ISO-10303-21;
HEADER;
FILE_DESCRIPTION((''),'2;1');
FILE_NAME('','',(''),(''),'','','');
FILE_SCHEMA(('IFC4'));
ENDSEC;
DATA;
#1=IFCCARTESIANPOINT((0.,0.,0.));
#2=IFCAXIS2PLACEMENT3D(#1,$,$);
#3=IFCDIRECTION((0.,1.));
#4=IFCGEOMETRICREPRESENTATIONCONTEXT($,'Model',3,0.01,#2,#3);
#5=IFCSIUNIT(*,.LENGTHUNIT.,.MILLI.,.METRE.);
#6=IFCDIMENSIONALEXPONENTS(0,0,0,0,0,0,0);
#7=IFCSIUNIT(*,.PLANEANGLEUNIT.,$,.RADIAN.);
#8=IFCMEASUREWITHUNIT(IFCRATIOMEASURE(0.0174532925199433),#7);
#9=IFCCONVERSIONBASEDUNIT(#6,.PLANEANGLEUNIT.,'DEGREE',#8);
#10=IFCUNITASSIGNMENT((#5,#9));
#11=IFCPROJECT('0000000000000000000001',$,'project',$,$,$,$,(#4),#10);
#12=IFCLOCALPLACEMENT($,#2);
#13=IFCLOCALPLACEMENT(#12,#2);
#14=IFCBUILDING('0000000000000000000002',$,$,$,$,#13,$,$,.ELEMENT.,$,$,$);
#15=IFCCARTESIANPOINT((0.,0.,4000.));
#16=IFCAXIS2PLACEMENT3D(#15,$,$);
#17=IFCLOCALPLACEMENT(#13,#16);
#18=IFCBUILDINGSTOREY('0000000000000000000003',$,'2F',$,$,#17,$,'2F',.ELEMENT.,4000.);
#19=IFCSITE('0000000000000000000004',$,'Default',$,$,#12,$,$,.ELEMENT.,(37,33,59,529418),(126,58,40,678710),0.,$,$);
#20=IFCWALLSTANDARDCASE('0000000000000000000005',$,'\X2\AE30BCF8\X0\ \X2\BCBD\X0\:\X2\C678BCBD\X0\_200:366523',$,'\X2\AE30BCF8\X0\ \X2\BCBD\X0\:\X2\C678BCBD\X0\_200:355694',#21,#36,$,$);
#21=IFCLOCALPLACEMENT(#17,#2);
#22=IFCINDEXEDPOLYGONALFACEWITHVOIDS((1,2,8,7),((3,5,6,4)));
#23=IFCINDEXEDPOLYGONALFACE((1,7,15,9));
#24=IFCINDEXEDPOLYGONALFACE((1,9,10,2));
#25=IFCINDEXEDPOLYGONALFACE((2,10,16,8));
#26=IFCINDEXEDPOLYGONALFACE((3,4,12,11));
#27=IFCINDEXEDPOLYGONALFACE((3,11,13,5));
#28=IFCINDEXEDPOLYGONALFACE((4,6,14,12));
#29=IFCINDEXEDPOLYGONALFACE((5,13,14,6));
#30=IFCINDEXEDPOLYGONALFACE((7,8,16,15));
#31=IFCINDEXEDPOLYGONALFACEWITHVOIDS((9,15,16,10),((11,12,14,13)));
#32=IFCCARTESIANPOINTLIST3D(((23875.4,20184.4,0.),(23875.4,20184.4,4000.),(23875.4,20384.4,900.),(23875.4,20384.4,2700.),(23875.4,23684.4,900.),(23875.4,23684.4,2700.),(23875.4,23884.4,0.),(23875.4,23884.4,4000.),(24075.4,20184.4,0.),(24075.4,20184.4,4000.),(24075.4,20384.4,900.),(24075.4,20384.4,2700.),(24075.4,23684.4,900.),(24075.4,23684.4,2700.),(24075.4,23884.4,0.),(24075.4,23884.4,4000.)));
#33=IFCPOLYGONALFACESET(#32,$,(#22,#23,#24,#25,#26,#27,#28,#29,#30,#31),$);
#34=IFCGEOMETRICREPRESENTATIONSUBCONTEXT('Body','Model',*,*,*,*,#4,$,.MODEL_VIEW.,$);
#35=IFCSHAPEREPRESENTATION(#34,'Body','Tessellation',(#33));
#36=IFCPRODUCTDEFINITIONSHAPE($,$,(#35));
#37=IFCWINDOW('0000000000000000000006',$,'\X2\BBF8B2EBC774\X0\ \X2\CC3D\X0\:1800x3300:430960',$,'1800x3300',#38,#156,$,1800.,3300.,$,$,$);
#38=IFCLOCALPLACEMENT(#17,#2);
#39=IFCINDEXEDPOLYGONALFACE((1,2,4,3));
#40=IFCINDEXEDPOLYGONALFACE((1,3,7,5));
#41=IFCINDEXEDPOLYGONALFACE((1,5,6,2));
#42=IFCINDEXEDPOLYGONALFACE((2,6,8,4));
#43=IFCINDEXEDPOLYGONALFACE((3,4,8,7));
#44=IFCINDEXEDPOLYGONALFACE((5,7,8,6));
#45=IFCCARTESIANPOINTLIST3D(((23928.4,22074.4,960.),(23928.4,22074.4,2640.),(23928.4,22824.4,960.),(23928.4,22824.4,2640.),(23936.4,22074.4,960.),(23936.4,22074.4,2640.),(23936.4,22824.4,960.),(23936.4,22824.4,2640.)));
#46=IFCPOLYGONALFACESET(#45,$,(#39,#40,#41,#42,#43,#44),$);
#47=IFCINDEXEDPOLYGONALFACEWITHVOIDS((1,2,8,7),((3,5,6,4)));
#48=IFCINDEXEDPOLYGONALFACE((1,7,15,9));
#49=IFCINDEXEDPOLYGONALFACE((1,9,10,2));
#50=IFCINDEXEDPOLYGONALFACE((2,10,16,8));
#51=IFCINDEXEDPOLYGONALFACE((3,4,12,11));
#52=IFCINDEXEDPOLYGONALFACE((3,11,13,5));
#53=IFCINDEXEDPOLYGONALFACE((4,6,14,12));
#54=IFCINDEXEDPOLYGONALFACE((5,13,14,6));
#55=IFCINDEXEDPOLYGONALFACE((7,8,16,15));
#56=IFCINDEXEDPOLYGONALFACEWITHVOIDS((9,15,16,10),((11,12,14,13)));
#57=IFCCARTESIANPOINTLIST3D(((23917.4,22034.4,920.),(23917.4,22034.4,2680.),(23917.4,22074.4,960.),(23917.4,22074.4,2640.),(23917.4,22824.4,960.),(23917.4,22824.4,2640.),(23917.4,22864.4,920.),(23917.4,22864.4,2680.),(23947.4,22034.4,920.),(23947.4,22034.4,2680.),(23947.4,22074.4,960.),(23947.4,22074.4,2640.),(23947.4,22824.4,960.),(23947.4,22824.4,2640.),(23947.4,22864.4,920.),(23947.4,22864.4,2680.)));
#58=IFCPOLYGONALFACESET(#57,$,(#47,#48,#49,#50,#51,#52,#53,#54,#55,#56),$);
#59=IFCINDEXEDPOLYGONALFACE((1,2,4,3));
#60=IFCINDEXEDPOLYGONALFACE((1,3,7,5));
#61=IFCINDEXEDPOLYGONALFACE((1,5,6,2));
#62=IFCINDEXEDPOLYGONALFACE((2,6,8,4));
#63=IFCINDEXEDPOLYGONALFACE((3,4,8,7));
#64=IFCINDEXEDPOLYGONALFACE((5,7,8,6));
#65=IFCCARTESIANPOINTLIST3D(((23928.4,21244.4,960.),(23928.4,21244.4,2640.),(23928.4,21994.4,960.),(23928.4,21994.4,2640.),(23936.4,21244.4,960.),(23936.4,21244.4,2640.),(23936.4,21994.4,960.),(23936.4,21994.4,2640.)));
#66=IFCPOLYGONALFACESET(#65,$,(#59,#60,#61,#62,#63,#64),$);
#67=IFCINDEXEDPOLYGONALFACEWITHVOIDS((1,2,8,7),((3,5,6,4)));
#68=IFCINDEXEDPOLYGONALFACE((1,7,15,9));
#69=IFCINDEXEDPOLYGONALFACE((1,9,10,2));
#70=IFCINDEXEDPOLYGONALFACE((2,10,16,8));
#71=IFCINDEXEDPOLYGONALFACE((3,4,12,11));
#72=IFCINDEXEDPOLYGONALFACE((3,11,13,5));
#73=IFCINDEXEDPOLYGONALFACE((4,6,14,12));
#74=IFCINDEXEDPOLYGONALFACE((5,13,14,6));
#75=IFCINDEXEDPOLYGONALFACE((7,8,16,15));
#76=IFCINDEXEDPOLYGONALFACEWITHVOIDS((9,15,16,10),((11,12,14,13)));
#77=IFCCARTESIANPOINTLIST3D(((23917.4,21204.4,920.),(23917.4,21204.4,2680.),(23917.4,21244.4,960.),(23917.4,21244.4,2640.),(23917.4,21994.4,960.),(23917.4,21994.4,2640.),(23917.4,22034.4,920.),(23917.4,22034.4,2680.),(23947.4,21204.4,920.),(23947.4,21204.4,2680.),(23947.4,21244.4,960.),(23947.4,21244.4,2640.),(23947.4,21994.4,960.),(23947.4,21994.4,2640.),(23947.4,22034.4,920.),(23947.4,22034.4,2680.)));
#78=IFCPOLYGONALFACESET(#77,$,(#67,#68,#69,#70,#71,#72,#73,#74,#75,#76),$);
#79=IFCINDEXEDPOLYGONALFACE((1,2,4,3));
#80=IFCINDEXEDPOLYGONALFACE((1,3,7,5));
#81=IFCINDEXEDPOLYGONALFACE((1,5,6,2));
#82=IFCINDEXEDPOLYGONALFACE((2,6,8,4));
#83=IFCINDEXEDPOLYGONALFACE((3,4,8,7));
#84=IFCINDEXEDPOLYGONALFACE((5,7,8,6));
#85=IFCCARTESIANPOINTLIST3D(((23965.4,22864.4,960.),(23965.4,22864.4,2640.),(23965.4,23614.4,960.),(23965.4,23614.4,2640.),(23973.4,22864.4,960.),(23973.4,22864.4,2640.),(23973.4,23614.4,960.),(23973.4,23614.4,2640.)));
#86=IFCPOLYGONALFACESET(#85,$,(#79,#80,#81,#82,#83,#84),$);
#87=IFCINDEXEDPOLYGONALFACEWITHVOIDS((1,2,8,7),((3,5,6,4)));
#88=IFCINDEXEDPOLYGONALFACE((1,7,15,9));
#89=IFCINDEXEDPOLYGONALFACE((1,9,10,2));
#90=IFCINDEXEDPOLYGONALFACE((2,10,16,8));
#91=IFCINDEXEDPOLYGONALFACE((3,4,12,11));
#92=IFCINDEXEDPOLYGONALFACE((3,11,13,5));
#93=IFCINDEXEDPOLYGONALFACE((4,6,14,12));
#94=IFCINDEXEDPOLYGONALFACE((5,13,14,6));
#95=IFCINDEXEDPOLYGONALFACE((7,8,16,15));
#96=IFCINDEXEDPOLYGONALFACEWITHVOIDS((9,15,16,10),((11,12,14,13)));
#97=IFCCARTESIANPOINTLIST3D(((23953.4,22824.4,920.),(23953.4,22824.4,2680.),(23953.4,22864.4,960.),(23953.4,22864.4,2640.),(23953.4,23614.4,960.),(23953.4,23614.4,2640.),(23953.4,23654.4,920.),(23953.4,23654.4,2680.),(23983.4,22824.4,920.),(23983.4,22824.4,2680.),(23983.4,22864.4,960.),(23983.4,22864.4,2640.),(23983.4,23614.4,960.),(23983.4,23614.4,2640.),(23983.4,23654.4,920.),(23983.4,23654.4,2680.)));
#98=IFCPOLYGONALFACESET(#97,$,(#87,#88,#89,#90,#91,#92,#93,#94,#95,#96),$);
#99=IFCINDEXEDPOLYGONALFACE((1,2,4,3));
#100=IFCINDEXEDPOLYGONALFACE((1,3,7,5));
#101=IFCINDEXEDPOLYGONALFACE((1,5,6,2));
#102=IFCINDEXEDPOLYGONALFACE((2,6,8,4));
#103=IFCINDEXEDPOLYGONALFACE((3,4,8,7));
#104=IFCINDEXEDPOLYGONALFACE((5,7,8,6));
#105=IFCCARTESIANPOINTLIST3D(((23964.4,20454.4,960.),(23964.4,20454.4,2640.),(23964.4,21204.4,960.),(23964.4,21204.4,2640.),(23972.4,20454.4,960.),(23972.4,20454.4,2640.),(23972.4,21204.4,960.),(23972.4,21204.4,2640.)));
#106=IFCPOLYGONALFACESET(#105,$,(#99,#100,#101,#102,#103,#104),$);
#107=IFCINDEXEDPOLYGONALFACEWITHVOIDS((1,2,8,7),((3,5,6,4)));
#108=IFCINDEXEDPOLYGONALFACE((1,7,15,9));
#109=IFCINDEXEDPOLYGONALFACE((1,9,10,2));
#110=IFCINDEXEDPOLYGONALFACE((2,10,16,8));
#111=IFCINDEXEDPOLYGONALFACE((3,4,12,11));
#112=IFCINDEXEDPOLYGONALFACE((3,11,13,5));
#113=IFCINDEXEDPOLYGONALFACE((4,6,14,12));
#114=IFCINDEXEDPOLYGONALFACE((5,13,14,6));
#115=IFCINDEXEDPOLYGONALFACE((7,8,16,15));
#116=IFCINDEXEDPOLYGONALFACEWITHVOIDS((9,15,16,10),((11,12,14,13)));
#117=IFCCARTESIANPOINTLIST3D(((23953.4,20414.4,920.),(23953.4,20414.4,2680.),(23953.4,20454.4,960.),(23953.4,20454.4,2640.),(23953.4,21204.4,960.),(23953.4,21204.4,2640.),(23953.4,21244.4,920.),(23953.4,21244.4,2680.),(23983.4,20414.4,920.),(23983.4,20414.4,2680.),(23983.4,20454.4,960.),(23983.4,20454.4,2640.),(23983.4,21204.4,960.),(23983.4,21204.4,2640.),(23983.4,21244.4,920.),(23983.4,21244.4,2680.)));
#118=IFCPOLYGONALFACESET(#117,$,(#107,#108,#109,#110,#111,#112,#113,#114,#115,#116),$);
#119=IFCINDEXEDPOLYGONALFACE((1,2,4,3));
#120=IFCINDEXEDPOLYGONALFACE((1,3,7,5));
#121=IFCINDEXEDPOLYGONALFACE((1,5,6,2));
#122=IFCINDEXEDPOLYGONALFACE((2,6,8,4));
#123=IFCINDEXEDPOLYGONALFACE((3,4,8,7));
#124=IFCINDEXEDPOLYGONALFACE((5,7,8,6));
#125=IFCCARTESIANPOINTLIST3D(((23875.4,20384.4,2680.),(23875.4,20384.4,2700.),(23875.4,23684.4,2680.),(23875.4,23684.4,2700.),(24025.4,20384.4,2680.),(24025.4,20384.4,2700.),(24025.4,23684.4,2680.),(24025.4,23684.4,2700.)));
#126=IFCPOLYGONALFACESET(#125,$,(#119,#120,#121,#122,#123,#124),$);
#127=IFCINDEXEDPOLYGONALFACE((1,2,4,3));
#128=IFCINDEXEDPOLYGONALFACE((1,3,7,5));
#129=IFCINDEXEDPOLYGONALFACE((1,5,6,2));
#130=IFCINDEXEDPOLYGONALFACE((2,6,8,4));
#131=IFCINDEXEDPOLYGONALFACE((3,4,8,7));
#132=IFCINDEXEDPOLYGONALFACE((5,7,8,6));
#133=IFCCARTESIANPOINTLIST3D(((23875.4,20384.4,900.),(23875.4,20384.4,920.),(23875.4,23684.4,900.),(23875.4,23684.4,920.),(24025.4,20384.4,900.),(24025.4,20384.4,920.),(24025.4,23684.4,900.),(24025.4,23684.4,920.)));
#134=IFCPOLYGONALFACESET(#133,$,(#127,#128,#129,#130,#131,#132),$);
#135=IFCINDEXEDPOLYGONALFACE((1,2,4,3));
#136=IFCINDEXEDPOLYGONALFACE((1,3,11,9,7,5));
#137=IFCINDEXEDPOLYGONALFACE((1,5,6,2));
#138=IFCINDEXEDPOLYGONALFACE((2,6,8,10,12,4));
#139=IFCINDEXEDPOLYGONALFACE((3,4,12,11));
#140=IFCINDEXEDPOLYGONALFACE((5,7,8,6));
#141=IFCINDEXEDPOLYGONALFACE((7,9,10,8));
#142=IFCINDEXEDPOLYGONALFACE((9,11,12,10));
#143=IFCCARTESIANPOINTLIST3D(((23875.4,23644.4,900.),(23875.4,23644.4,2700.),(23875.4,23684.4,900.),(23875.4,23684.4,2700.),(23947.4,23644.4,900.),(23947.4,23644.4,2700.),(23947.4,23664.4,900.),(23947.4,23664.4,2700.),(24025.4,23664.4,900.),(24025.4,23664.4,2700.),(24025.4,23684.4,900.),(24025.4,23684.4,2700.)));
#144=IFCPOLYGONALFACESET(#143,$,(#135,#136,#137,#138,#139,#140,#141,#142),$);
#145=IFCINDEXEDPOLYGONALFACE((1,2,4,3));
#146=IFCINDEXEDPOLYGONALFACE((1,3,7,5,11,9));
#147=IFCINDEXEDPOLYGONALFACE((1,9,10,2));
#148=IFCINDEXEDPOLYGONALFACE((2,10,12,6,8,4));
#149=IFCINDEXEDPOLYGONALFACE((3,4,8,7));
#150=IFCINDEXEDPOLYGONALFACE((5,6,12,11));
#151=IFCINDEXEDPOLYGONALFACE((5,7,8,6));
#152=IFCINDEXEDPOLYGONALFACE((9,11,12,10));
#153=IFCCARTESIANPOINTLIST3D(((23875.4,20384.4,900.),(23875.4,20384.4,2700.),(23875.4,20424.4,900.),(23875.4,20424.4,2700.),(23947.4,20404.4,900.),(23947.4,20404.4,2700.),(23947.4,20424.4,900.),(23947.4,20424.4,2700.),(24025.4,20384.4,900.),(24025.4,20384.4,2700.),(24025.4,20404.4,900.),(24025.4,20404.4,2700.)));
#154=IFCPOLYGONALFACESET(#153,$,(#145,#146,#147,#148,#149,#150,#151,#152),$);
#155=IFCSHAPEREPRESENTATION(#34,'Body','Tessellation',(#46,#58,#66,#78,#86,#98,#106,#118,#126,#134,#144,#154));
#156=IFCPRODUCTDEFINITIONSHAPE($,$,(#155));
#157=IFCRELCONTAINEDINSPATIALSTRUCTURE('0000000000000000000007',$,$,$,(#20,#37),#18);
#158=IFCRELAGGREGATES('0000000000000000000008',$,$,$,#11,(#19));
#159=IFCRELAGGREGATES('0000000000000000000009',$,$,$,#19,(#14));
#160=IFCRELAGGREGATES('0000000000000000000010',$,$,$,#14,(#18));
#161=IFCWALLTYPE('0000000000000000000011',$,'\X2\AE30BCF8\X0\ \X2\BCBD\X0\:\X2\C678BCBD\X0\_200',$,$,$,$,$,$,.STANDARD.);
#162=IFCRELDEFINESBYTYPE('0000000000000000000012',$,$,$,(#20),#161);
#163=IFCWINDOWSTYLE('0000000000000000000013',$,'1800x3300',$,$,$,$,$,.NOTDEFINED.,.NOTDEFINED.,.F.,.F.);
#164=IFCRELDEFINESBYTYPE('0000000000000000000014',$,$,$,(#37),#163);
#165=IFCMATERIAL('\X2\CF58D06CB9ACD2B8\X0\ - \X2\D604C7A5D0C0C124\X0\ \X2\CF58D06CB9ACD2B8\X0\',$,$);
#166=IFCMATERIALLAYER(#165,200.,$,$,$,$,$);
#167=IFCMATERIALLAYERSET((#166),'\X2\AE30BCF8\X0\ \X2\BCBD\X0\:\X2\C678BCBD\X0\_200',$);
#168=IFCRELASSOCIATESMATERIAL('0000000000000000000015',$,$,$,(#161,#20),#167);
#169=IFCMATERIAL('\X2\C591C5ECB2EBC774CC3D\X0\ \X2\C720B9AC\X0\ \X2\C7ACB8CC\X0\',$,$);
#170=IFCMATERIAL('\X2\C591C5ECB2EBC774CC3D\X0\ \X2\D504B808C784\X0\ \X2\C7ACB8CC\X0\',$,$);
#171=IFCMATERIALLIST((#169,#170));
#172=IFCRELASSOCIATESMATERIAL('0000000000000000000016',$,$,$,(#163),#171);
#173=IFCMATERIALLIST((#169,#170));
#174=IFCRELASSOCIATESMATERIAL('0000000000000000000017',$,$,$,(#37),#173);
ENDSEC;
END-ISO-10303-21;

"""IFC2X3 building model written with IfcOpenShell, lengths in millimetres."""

from ifc_helpers import new_model, entity, si_unit, converted_unit, direction, frame, frame_2d, origin, origin_2d_with_axis, place, context, subcontext, project, spatial, polyline, rectangle, outline, extrude, source, transform, mapped, material, material_list, layer, layer_set, layer_usage, type_object, type_shapes, element, fill, save


model = new_model("IFC2X3")

# Units and contexts
model_context = context("Model", 3, precision=0.01, world=origin(), true_north=direction((0.0, 1.0)))
body_context = subcontext(model_context, "Body", "Model", "MODEL_VIEW")
ifc_project = project(units=[si_unit("LENGTHUNIT", "METRE", prefix="MILLI"), converted_unit("PLANEANGLEUNIT", "DEGREE", entity("IfcRatioMeasure", 0.0174532925199433), si_unit("PLANEANGLEUNIT", "RADIAN"), dimensions=[0, 0, 0, 0, 0, 0, 0])], contexts=[model_context])

# Site, building, storey
site_placement = place(None, origin())
site = spatial("IfcSite", under=ifc_project, at=site_placement, Name="Default", CompositionType="ELEMENT", RefLatitude=(37, 33, 59, 529418), RefLongitude=(126, 58, 40, 678710), RefElevation=0.0)
building_placement = place(site_placement, origin())
building = spatial("IfcBuilding", under=site, at=building_placement, CompositionType="ELEMENT")
storey_placement = place(building_placement, frame((0.0, 0.0, 4000.0)))
storey = spatial("IfcBuildingStorey", under=building, at=storey_placement, Name="2F", LongName="2F", CompositionType="ELEMENT", Elevation=4000.0)

# Shared definitions
ifc_material_1 = material(Name="콘크리트 - 현장타설 콘크리트")

# Wall, opening, window
ifc_layer_1 = layer(ifc_material_1, 200.0)
ifc_layer_set_1 = layer_set([ifc_layer_1], Name="기본 벽:외벽_200")
wall_type_1 = type_object("IfcWallType", Name="기본 벽:외벽_200", PredefinedType="STANDARD", material=ifc_layer_set_1)
ifc_material_2 = material(Name="양여닫이창 유리 재료")
ifc_material_3 = material(Name="양여닫이창 프레임 재료")
ifc_material_list_1 = material_list([ifc_material_2, ifc_material_3])
window_style_1 = type_object("IfcWindowStyle", Name="1800x3300", ConstructionType="NOTDEFINED", OperationType="NOTDEFINED", ParameterTakesPrecedence=False, Sizeable=False, material=ifc_material_list_1)
shared_shape_1 = source(origin(), body_context, "Body", "SweptSolid", [
    extrude(rectangle(XDim=8.0, YDim=750.0, at=frame_2d((0.0, 0.0), x_axis=(1.0, 0.0))), frame((2065.0, 143.0, 60.0), z_axis=(0.0, 0.0, 1.0), x_axis=(0.0, 1.0, 0.0)), (0.0, 0.0, 1.0), 1680.0),
    extrude(outline(polyline([(-880.0, -415.0), (880.0, -415.0), (880.0, 415.0), (-880.0, 415.0), (-880.0, -415.0)]), holes=[polyline([(840.0, -375.0), (-840.0, -375.0), (-840.0, 375.0), (840.0, 375.0), (840.0, -375.0)])]), frame((2065.0, 128.0, 900.0), z_axis=(0.0, 1.0, 0.0), x_axis=(0.0, 0.0, -1.0)), (0.0, 0.0, 1.0), 30.0),
    extrude(rectangle(XDim=8.0, YDim=750.0, at=frame_2d((0.0, 0.0), x_axis=(1.0, 0.0))), frame((1235.0, 143.0, 60.0), z_axis=(0.0, 0.0, 1.0), x_axis=(0.0, 1.0, 0.0)), (0.0, 0.0, 1.0), 1680.0),
    extrude(outline(polyline([(-880.0, -415.0), (880.0, -415.0), (880.0, 415.0), (-880.0, 415.0), (-880.0, -415.0)]), holes=[polyline([(840.0, -375.0), (-840.0, -375.0), (-840.0, 375.0), (840.0, 375.0), (840.0, -375.0)])]), frame((1235.0, 128.0, 900.0), z_axis=(0.0, 1.0, 0.0), x_axis=(0.0, 0.0, -1.0)), (0.0, 0.0, 1.0), 30.0),
    extrude(rectangle(XDim=8.0, YDim=750.0, at=frame_2d((0.0, 0.0), x_axis=(1.0, 0.0))), frame((2855.0, 106.0, 60.0), z_axis=(0.0, 0.0, 1.0), x_axis=(0.0, 1.0, 0.0)), (0.0, 0.0, 1.0), 1680.0),
    extrude(outline(polyline([(-880.0, -415.0), (880.0, -415.0), (880.0, 415.0), (-880.0, 415.0), (-880.0, -415.0)]), holes=[polyline([(840.0, -375.0), (-840.0, -375.0), (-840.0, 375.0), (840.0, 375.0), (840.0, -375.0)])]), frame((2855.0, 92.0, 900.0), z_axis=(0.0, 1.0, 0.0), x_axis=(0.0, 0.0, -1.0)), (0.0, 0.0, 1.0), 30.0),
    extrude(rectangle(XDim=8.0, YDim=750.0, at=origin_2d_with_axis()), frame((445.0, 107.0, 60.0), z_axis=(0.0, 0.0, 1.0), x_axis=(0.0, 1.0, 0.0)), (0.0, 0.0, 1.0), 1680.0),
    extrude(outline(polyline([(-880.0, -415.0), (880.0, -415.0), (880.0, 415.0), (-880.0, 415.0), (-880.0, -415.0)]), holes=[polyline([(840.0, -375.0), (-840.0, -375.0), (-840.0, 375.0), (840.0, 375.0), (840.0, -375.0)])]), frame((445.0, 92.0, 900.0), z_axis=(0.0, 1.0, 0.0), x_axis=(0.0, 0.0, -1.0)), (0.0, 0.0, 1.0), 30.0),
    extrude(rectangle(XDim=3300.0, YDim=150.0, at=origin_2d_with_axis()), frame((1650.0, 125.0, 1780.0), z_axis=(0.0, 0.0, 1.0), x_axis=(-1.0, 0.0, 0.0)), (0.0, 0.0, 1.0), 20.0),
    extrude(rectangle(XDim=3300.0, YDim=150.0, at=origin_2d_with_axis()), frame((1650.0, 125.0, 0.0), z_axis=(0.0, 0.0, 1.0), x_axis=(-1.0, 0.0, 0.0)), (0.0, 0.0, 1.0), 20.0),
    extrude(outline(polyline([(-74.0, -20.0), (-2.0, -20.0), (-2.0, 0.0), (76.0, 0.0), (76.0, 20.0), (-74.0, 20.0), (-74.0, -20.0)])), frame((3280.0, 126.0, 0.0), z_axis=(0.0, 0.0, 1.0), x_axis=(0.0, -1.0, 0.0)), (0.0, 0.0, 1.0), 1800.0),
    extrude(outline(polyline([(-20.0, -74.0), (20.0, -74.0), (20.0, 76.0), (0.0, 76.0), (0.0, -2.0), (-20.0, -2.0), (-20.0, -74.0)])), frame((20.0, 126.0, 0.0), z_axis=(0.0, 0.0, 1.0), x_axis=(-1.0, 0.0, 0.0)), (0.0, 0.0, 1.0), 1800.0),
])
type_shapes(window_style_1, [shared_shape_1])
ifc_layer_usage_1 = layer_usage(ifc_layer_set_1, "AXIS2", "NEGATIVE", 100.0)
wall_1_placement = place(storey_placement, frame((23975.4, 20184.4, 0.0), z_axis=(0.0, 0.0, 1.0), x_axis=(0.0, 1.0, 0.0)))
wall_1 = element("IfcWallStandardCase", 1, at=wall_1_placement, inside=storey, type_object=wall_type_1, material=ifc_layer_usage_1, Name="기본 벽:외벽_200:366523", ObjectType="기본 벽:외벽_200:355694", context=body_context, shape_type="SweptSolid", body=[
    extrude(rectangle(XDim=3700.0, YDim=200.0, at=frame_2d((1850.0, 0.0), x_axis=(-1.0, 0.0))), origin(), (0.0, 0.0, 1.0), 4000.0),
])
opening_1_placement = place(wall_1_placement, frame((200.0, -100.0, 900.0)))
opening_1 = element("IfcOpeningElement", 2, at=opening_1_placement, cuts=wall_1, ObjectType="Opening", context=body_context, shape_type="SweptSolid", body=[
    extrude(rectangle(XDim=1800.0, YDim=3300.0, at=frame_2d((900.0, 1650.0), x_axis=(1.0, 0.0))), frame((0.0, 0.0, 0.0), z_axis=(0.0, 1.0, 0.0), x_axis=(0.0, 0.0, 1.0)), (0.0, 0.0, 1.0), 200.0),
])
ifc_material_list_2 = material_list([ifc_material_2, ifc_material_3])
window_1_placement = place(opening_1_placement, origin())
window_1 = element("IfcWindow", 3, at=window_1_placement, inside=storey, type_object=window_style_1, material=ifc_material_list_2, Name="미닫이 창:1800x3300:430960", ObjectType="1800x3300", OverallHeight=1800.0, OverallWidth=3300.0, context=body_context, shape_type="MappedRepresentation", body=[
    mapped(shared_shape_1, transform((0.0, 0.0, 0.0), scale=1.0)),
])
fill(opening_1, window_1)

save(model, "model.ifc")
